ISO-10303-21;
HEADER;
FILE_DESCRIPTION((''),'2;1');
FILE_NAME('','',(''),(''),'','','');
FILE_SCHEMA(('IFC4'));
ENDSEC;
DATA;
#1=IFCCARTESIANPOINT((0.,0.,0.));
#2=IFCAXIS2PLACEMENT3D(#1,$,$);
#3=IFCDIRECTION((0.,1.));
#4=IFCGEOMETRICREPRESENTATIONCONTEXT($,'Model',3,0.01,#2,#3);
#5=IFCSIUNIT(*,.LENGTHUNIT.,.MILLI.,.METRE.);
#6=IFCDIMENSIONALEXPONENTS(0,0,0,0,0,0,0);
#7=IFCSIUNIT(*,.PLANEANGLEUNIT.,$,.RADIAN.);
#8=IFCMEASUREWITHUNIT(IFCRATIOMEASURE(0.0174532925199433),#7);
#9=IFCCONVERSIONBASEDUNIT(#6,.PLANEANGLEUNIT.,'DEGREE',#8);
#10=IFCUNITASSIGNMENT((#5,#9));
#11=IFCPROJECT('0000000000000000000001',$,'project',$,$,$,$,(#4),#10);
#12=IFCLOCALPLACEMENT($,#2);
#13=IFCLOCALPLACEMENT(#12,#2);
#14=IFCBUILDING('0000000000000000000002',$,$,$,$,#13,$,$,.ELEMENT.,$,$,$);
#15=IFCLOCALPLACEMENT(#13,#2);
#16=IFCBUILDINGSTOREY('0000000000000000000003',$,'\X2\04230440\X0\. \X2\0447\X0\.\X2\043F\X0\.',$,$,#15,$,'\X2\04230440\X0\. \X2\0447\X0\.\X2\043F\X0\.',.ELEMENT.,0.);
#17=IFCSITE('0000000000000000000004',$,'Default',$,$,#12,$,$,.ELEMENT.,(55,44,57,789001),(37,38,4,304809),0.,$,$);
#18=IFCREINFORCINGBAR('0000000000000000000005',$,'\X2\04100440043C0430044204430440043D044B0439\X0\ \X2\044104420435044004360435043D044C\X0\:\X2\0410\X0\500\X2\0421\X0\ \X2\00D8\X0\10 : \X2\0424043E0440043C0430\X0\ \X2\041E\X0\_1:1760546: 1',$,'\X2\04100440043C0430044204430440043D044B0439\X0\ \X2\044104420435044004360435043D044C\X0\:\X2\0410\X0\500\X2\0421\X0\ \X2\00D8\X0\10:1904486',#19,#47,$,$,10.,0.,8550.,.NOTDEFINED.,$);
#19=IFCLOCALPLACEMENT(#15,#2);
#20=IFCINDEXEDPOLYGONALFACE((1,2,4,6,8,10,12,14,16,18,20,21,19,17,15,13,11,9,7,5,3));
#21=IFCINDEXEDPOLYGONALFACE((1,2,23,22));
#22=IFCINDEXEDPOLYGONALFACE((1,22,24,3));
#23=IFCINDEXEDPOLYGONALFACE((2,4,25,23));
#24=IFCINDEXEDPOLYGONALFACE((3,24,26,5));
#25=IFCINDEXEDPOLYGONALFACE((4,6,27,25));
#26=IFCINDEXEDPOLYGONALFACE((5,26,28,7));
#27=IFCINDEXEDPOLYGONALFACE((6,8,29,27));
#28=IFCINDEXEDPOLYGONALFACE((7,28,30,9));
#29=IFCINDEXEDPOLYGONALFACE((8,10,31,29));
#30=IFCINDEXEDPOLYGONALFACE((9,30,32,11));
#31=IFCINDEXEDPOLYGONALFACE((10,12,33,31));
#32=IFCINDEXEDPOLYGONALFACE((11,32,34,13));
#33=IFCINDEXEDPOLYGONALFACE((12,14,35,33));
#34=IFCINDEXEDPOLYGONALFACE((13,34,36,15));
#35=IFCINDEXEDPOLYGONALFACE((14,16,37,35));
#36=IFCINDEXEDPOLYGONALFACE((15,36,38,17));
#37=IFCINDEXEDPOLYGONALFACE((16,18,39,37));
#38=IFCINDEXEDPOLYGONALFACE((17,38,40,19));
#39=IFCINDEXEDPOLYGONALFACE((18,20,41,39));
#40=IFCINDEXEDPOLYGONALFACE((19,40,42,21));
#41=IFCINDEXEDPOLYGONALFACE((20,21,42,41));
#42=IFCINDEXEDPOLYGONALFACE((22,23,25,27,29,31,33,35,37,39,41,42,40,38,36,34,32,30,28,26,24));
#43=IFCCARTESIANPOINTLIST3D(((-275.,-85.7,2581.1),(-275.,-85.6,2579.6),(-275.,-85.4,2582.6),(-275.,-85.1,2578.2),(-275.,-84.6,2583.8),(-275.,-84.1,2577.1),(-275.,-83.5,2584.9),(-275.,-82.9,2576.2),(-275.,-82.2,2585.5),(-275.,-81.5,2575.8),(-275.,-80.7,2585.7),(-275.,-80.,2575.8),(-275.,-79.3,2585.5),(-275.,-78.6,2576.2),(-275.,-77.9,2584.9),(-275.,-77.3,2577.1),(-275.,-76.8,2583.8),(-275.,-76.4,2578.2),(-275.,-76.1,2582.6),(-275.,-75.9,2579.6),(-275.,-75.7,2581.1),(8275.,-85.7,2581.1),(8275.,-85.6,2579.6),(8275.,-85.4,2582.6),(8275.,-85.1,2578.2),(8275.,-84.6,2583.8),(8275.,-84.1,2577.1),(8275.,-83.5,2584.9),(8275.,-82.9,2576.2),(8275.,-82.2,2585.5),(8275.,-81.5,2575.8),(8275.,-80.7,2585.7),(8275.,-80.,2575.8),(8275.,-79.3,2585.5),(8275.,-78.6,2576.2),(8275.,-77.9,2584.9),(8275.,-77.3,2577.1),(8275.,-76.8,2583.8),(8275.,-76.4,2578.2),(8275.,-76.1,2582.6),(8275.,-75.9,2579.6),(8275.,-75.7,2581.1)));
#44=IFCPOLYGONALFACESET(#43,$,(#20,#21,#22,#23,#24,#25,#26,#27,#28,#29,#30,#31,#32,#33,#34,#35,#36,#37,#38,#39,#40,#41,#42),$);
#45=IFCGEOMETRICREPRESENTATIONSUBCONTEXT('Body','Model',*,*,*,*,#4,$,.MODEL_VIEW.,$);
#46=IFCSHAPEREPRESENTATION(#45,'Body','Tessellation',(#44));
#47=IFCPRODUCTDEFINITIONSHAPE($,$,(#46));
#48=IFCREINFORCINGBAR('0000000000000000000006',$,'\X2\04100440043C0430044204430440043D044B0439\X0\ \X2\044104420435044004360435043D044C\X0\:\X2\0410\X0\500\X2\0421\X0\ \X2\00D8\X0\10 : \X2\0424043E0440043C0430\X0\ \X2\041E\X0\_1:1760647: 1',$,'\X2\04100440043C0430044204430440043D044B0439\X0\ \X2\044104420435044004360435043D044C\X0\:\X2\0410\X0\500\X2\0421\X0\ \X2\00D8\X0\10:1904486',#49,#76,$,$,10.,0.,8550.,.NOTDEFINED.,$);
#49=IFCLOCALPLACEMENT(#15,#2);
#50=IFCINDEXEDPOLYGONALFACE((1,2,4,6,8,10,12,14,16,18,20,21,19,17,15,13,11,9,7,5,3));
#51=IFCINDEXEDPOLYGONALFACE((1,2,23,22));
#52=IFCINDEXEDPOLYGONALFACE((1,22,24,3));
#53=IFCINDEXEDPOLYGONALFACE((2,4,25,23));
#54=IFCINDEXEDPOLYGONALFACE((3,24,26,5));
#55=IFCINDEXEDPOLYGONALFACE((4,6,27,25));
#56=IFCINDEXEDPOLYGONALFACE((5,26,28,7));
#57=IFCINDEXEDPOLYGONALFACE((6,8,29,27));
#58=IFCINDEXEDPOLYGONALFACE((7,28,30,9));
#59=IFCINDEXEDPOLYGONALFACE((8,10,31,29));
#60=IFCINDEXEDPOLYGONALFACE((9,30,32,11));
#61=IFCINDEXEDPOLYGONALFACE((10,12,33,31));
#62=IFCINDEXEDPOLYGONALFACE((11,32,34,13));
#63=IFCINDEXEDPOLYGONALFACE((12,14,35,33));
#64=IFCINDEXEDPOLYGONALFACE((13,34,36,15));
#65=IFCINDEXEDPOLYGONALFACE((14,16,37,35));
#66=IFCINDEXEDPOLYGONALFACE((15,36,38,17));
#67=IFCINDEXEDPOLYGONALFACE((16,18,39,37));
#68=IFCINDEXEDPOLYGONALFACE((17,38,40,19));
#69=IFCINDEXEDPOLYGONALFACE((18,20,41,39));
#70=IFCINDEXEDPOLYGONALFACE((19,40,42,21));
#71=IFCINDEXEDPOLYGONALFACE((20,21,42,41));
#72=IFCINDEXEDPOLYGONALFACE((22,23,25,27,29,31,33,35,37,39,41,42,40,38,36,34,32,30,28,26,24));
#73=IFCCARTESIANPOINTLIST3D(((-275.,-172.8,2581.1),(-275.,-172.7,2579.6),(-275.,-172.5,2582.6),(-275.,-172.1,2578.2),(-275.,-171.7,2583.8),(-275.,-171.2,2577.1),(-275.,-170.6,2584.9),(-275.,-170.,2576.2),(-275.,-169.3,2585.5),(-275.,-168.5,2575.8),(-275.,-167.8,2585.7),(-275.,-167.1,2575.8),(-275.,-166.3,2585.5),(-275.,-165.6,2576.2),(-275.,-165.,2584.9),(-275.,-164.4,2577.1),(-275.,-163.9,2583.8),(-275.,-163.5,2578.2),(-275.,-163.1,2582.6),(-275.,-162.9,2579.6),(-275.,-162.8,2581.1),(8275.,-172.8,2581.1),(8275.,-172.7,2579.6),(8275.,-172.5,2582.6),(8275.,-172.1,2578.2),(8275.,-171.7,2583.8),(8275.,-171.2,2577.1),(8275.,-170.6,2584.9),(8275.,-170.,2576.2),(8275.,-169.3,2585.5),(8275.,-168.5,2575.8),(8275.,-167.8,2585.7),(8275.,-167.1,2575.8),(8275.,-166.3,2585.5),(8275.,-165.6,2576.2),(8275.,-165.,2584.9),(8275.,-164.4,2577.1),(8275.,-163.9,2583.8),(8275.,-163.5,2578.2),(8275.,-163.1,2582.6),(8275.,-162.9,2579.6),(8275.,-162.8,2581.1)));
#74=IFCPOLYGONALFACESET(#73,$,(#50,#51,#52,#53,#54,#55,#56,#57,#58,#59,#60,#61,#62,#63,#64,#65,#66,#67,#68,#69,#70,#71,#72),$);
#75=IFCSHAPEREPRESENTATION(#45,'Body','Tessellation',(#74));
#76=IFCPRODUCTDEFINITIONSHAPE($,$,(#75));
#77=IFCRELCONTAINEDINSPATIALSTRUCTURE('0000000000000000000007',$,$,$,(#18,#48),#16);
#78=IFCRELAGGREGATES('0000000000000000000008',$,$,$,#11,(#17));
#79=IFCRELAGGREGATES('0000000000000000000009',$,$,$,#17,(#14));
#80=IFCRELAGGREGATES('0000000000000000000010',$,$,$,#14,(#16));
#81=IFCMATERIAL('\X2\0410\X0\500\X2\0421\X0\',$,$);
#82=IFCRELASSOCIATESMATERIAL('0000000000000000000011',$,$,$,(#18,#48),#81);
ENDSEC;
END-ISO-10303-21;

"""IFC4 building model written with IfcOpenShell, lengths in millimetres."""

from ifc_helpers import new_model, entity, si_unit, converted_unit, direction, origin, place, context, subcontext, project, spatial, material, element, save


model = new_model("IFC4")

# Units and contexts
model_context = context("Model", 3, precision=0.01, world=origin(), true_north=direction((0.0, 1.0)))
body_context = subcontext(model_context, "Body", "Model", "MODEL_VIEW")
ifc_project = project(units=[si_unit("LENGTHUNIT", "METRE", prefix="MILLI"), converted_unit("PLANEANGLEUNIT", "DEGREE", entity("IfcRatioMeasure", 0.0174532925199433), si_unit("PLANEANGLEUNIT", "RADIAN"), dimensions=[0, 0, 0, 0, 0, 0, 0])], contexts=[model_context])

# Site, building, storey
site_placement = place(None, origin())
site = spatial("IfcSite", under=ifc_project, at=site_placement, Name="Default", CompositionType="ELEMENT", RefLatitude=(55, 44, 57, 789001), RefLongitude=(37, 38, 4, 304809), RefElevation=0.0)
building_placement = place(site_placement, origin())
building = spatial("IfcBuilding", under=site, at=building_placement, CompositionType="ELEMENT")
storey_placement = place(building_placement, origin())
storey = spatial("IfcBuildingStorey", under=building, at=storey_placement, Name="Ур. ч.п.", LongName="Ур. ч.п.", CompositionType="ELEMENT", Elevation=0.0)

# Reinforcing bars
ifc_material_1 = material(Name="А500С")
reinforcing_bar_1_placement = place(storey_placement, origin())
element("IfcReinforcingBar", 1, at=reinforcing_bar_1_placement, inside=storey, material=ifc_material_1, Name="Арматурный стержень:А500С Ø10 : Форма О_1:1760546: 1", ObjectType="Арматурный стержень:А500С Ø10:1904486", BarLength=8550.0, CrossSectionArea=0.0, NominalDiameter=10.0, PredefinedType="NOTDEFINED", context=body_context, shape_type="AdvancedSweptSolid", body=[
    entity("IfcSweptDiskSolid", entity("IfcCompositeCurve", [entity("IfcCompositeCurveSegment", "CONTINUOUS", True, entity("IfcPolyline", [entity("IfcCartesianPoint", [-275.0, -80.7, 2580.7]), entity("IfcCartesianPoint", [8275.0, -80.7, 2580.7])]))], False), 5.0, None, 0.0, 1.0),
])
reinforcing_bar_2_placement = place(storey_placement, origin())
element("IfcReinforcingBar", 2, at=reinforcing_bar_2_placement, inside=storey, material=ifc_material_1, Name="Арматурный стержень:А500С Ø10 : Форма О_1:1760647: 1", ObjectType="Арматурный стержень:А500С Ø10:1904486", BarLength=8550.0, CrossSectionArea=0.0, NominalDiameter=10.0, PredefinedType="NOTDEFINED", context=body_context, shape_type="AdvancedSweptSolid", body=[
    entity("IfcSweptDiskSolid", entity("IfcCompositeCurve", [entity("IfcCompositeCurveSegment", "CONTINUOUS", True, entity("IfcPolyline", [entity("IfcCartesianPoint", [-275.0, -167.8, 2580.7]), entity("IfcCartesianPoint", [8275.0, -167.8, 2580.7])]))], False), 5.0, None, 0.0, 1.0),
])

save(model, "model.ifc")
